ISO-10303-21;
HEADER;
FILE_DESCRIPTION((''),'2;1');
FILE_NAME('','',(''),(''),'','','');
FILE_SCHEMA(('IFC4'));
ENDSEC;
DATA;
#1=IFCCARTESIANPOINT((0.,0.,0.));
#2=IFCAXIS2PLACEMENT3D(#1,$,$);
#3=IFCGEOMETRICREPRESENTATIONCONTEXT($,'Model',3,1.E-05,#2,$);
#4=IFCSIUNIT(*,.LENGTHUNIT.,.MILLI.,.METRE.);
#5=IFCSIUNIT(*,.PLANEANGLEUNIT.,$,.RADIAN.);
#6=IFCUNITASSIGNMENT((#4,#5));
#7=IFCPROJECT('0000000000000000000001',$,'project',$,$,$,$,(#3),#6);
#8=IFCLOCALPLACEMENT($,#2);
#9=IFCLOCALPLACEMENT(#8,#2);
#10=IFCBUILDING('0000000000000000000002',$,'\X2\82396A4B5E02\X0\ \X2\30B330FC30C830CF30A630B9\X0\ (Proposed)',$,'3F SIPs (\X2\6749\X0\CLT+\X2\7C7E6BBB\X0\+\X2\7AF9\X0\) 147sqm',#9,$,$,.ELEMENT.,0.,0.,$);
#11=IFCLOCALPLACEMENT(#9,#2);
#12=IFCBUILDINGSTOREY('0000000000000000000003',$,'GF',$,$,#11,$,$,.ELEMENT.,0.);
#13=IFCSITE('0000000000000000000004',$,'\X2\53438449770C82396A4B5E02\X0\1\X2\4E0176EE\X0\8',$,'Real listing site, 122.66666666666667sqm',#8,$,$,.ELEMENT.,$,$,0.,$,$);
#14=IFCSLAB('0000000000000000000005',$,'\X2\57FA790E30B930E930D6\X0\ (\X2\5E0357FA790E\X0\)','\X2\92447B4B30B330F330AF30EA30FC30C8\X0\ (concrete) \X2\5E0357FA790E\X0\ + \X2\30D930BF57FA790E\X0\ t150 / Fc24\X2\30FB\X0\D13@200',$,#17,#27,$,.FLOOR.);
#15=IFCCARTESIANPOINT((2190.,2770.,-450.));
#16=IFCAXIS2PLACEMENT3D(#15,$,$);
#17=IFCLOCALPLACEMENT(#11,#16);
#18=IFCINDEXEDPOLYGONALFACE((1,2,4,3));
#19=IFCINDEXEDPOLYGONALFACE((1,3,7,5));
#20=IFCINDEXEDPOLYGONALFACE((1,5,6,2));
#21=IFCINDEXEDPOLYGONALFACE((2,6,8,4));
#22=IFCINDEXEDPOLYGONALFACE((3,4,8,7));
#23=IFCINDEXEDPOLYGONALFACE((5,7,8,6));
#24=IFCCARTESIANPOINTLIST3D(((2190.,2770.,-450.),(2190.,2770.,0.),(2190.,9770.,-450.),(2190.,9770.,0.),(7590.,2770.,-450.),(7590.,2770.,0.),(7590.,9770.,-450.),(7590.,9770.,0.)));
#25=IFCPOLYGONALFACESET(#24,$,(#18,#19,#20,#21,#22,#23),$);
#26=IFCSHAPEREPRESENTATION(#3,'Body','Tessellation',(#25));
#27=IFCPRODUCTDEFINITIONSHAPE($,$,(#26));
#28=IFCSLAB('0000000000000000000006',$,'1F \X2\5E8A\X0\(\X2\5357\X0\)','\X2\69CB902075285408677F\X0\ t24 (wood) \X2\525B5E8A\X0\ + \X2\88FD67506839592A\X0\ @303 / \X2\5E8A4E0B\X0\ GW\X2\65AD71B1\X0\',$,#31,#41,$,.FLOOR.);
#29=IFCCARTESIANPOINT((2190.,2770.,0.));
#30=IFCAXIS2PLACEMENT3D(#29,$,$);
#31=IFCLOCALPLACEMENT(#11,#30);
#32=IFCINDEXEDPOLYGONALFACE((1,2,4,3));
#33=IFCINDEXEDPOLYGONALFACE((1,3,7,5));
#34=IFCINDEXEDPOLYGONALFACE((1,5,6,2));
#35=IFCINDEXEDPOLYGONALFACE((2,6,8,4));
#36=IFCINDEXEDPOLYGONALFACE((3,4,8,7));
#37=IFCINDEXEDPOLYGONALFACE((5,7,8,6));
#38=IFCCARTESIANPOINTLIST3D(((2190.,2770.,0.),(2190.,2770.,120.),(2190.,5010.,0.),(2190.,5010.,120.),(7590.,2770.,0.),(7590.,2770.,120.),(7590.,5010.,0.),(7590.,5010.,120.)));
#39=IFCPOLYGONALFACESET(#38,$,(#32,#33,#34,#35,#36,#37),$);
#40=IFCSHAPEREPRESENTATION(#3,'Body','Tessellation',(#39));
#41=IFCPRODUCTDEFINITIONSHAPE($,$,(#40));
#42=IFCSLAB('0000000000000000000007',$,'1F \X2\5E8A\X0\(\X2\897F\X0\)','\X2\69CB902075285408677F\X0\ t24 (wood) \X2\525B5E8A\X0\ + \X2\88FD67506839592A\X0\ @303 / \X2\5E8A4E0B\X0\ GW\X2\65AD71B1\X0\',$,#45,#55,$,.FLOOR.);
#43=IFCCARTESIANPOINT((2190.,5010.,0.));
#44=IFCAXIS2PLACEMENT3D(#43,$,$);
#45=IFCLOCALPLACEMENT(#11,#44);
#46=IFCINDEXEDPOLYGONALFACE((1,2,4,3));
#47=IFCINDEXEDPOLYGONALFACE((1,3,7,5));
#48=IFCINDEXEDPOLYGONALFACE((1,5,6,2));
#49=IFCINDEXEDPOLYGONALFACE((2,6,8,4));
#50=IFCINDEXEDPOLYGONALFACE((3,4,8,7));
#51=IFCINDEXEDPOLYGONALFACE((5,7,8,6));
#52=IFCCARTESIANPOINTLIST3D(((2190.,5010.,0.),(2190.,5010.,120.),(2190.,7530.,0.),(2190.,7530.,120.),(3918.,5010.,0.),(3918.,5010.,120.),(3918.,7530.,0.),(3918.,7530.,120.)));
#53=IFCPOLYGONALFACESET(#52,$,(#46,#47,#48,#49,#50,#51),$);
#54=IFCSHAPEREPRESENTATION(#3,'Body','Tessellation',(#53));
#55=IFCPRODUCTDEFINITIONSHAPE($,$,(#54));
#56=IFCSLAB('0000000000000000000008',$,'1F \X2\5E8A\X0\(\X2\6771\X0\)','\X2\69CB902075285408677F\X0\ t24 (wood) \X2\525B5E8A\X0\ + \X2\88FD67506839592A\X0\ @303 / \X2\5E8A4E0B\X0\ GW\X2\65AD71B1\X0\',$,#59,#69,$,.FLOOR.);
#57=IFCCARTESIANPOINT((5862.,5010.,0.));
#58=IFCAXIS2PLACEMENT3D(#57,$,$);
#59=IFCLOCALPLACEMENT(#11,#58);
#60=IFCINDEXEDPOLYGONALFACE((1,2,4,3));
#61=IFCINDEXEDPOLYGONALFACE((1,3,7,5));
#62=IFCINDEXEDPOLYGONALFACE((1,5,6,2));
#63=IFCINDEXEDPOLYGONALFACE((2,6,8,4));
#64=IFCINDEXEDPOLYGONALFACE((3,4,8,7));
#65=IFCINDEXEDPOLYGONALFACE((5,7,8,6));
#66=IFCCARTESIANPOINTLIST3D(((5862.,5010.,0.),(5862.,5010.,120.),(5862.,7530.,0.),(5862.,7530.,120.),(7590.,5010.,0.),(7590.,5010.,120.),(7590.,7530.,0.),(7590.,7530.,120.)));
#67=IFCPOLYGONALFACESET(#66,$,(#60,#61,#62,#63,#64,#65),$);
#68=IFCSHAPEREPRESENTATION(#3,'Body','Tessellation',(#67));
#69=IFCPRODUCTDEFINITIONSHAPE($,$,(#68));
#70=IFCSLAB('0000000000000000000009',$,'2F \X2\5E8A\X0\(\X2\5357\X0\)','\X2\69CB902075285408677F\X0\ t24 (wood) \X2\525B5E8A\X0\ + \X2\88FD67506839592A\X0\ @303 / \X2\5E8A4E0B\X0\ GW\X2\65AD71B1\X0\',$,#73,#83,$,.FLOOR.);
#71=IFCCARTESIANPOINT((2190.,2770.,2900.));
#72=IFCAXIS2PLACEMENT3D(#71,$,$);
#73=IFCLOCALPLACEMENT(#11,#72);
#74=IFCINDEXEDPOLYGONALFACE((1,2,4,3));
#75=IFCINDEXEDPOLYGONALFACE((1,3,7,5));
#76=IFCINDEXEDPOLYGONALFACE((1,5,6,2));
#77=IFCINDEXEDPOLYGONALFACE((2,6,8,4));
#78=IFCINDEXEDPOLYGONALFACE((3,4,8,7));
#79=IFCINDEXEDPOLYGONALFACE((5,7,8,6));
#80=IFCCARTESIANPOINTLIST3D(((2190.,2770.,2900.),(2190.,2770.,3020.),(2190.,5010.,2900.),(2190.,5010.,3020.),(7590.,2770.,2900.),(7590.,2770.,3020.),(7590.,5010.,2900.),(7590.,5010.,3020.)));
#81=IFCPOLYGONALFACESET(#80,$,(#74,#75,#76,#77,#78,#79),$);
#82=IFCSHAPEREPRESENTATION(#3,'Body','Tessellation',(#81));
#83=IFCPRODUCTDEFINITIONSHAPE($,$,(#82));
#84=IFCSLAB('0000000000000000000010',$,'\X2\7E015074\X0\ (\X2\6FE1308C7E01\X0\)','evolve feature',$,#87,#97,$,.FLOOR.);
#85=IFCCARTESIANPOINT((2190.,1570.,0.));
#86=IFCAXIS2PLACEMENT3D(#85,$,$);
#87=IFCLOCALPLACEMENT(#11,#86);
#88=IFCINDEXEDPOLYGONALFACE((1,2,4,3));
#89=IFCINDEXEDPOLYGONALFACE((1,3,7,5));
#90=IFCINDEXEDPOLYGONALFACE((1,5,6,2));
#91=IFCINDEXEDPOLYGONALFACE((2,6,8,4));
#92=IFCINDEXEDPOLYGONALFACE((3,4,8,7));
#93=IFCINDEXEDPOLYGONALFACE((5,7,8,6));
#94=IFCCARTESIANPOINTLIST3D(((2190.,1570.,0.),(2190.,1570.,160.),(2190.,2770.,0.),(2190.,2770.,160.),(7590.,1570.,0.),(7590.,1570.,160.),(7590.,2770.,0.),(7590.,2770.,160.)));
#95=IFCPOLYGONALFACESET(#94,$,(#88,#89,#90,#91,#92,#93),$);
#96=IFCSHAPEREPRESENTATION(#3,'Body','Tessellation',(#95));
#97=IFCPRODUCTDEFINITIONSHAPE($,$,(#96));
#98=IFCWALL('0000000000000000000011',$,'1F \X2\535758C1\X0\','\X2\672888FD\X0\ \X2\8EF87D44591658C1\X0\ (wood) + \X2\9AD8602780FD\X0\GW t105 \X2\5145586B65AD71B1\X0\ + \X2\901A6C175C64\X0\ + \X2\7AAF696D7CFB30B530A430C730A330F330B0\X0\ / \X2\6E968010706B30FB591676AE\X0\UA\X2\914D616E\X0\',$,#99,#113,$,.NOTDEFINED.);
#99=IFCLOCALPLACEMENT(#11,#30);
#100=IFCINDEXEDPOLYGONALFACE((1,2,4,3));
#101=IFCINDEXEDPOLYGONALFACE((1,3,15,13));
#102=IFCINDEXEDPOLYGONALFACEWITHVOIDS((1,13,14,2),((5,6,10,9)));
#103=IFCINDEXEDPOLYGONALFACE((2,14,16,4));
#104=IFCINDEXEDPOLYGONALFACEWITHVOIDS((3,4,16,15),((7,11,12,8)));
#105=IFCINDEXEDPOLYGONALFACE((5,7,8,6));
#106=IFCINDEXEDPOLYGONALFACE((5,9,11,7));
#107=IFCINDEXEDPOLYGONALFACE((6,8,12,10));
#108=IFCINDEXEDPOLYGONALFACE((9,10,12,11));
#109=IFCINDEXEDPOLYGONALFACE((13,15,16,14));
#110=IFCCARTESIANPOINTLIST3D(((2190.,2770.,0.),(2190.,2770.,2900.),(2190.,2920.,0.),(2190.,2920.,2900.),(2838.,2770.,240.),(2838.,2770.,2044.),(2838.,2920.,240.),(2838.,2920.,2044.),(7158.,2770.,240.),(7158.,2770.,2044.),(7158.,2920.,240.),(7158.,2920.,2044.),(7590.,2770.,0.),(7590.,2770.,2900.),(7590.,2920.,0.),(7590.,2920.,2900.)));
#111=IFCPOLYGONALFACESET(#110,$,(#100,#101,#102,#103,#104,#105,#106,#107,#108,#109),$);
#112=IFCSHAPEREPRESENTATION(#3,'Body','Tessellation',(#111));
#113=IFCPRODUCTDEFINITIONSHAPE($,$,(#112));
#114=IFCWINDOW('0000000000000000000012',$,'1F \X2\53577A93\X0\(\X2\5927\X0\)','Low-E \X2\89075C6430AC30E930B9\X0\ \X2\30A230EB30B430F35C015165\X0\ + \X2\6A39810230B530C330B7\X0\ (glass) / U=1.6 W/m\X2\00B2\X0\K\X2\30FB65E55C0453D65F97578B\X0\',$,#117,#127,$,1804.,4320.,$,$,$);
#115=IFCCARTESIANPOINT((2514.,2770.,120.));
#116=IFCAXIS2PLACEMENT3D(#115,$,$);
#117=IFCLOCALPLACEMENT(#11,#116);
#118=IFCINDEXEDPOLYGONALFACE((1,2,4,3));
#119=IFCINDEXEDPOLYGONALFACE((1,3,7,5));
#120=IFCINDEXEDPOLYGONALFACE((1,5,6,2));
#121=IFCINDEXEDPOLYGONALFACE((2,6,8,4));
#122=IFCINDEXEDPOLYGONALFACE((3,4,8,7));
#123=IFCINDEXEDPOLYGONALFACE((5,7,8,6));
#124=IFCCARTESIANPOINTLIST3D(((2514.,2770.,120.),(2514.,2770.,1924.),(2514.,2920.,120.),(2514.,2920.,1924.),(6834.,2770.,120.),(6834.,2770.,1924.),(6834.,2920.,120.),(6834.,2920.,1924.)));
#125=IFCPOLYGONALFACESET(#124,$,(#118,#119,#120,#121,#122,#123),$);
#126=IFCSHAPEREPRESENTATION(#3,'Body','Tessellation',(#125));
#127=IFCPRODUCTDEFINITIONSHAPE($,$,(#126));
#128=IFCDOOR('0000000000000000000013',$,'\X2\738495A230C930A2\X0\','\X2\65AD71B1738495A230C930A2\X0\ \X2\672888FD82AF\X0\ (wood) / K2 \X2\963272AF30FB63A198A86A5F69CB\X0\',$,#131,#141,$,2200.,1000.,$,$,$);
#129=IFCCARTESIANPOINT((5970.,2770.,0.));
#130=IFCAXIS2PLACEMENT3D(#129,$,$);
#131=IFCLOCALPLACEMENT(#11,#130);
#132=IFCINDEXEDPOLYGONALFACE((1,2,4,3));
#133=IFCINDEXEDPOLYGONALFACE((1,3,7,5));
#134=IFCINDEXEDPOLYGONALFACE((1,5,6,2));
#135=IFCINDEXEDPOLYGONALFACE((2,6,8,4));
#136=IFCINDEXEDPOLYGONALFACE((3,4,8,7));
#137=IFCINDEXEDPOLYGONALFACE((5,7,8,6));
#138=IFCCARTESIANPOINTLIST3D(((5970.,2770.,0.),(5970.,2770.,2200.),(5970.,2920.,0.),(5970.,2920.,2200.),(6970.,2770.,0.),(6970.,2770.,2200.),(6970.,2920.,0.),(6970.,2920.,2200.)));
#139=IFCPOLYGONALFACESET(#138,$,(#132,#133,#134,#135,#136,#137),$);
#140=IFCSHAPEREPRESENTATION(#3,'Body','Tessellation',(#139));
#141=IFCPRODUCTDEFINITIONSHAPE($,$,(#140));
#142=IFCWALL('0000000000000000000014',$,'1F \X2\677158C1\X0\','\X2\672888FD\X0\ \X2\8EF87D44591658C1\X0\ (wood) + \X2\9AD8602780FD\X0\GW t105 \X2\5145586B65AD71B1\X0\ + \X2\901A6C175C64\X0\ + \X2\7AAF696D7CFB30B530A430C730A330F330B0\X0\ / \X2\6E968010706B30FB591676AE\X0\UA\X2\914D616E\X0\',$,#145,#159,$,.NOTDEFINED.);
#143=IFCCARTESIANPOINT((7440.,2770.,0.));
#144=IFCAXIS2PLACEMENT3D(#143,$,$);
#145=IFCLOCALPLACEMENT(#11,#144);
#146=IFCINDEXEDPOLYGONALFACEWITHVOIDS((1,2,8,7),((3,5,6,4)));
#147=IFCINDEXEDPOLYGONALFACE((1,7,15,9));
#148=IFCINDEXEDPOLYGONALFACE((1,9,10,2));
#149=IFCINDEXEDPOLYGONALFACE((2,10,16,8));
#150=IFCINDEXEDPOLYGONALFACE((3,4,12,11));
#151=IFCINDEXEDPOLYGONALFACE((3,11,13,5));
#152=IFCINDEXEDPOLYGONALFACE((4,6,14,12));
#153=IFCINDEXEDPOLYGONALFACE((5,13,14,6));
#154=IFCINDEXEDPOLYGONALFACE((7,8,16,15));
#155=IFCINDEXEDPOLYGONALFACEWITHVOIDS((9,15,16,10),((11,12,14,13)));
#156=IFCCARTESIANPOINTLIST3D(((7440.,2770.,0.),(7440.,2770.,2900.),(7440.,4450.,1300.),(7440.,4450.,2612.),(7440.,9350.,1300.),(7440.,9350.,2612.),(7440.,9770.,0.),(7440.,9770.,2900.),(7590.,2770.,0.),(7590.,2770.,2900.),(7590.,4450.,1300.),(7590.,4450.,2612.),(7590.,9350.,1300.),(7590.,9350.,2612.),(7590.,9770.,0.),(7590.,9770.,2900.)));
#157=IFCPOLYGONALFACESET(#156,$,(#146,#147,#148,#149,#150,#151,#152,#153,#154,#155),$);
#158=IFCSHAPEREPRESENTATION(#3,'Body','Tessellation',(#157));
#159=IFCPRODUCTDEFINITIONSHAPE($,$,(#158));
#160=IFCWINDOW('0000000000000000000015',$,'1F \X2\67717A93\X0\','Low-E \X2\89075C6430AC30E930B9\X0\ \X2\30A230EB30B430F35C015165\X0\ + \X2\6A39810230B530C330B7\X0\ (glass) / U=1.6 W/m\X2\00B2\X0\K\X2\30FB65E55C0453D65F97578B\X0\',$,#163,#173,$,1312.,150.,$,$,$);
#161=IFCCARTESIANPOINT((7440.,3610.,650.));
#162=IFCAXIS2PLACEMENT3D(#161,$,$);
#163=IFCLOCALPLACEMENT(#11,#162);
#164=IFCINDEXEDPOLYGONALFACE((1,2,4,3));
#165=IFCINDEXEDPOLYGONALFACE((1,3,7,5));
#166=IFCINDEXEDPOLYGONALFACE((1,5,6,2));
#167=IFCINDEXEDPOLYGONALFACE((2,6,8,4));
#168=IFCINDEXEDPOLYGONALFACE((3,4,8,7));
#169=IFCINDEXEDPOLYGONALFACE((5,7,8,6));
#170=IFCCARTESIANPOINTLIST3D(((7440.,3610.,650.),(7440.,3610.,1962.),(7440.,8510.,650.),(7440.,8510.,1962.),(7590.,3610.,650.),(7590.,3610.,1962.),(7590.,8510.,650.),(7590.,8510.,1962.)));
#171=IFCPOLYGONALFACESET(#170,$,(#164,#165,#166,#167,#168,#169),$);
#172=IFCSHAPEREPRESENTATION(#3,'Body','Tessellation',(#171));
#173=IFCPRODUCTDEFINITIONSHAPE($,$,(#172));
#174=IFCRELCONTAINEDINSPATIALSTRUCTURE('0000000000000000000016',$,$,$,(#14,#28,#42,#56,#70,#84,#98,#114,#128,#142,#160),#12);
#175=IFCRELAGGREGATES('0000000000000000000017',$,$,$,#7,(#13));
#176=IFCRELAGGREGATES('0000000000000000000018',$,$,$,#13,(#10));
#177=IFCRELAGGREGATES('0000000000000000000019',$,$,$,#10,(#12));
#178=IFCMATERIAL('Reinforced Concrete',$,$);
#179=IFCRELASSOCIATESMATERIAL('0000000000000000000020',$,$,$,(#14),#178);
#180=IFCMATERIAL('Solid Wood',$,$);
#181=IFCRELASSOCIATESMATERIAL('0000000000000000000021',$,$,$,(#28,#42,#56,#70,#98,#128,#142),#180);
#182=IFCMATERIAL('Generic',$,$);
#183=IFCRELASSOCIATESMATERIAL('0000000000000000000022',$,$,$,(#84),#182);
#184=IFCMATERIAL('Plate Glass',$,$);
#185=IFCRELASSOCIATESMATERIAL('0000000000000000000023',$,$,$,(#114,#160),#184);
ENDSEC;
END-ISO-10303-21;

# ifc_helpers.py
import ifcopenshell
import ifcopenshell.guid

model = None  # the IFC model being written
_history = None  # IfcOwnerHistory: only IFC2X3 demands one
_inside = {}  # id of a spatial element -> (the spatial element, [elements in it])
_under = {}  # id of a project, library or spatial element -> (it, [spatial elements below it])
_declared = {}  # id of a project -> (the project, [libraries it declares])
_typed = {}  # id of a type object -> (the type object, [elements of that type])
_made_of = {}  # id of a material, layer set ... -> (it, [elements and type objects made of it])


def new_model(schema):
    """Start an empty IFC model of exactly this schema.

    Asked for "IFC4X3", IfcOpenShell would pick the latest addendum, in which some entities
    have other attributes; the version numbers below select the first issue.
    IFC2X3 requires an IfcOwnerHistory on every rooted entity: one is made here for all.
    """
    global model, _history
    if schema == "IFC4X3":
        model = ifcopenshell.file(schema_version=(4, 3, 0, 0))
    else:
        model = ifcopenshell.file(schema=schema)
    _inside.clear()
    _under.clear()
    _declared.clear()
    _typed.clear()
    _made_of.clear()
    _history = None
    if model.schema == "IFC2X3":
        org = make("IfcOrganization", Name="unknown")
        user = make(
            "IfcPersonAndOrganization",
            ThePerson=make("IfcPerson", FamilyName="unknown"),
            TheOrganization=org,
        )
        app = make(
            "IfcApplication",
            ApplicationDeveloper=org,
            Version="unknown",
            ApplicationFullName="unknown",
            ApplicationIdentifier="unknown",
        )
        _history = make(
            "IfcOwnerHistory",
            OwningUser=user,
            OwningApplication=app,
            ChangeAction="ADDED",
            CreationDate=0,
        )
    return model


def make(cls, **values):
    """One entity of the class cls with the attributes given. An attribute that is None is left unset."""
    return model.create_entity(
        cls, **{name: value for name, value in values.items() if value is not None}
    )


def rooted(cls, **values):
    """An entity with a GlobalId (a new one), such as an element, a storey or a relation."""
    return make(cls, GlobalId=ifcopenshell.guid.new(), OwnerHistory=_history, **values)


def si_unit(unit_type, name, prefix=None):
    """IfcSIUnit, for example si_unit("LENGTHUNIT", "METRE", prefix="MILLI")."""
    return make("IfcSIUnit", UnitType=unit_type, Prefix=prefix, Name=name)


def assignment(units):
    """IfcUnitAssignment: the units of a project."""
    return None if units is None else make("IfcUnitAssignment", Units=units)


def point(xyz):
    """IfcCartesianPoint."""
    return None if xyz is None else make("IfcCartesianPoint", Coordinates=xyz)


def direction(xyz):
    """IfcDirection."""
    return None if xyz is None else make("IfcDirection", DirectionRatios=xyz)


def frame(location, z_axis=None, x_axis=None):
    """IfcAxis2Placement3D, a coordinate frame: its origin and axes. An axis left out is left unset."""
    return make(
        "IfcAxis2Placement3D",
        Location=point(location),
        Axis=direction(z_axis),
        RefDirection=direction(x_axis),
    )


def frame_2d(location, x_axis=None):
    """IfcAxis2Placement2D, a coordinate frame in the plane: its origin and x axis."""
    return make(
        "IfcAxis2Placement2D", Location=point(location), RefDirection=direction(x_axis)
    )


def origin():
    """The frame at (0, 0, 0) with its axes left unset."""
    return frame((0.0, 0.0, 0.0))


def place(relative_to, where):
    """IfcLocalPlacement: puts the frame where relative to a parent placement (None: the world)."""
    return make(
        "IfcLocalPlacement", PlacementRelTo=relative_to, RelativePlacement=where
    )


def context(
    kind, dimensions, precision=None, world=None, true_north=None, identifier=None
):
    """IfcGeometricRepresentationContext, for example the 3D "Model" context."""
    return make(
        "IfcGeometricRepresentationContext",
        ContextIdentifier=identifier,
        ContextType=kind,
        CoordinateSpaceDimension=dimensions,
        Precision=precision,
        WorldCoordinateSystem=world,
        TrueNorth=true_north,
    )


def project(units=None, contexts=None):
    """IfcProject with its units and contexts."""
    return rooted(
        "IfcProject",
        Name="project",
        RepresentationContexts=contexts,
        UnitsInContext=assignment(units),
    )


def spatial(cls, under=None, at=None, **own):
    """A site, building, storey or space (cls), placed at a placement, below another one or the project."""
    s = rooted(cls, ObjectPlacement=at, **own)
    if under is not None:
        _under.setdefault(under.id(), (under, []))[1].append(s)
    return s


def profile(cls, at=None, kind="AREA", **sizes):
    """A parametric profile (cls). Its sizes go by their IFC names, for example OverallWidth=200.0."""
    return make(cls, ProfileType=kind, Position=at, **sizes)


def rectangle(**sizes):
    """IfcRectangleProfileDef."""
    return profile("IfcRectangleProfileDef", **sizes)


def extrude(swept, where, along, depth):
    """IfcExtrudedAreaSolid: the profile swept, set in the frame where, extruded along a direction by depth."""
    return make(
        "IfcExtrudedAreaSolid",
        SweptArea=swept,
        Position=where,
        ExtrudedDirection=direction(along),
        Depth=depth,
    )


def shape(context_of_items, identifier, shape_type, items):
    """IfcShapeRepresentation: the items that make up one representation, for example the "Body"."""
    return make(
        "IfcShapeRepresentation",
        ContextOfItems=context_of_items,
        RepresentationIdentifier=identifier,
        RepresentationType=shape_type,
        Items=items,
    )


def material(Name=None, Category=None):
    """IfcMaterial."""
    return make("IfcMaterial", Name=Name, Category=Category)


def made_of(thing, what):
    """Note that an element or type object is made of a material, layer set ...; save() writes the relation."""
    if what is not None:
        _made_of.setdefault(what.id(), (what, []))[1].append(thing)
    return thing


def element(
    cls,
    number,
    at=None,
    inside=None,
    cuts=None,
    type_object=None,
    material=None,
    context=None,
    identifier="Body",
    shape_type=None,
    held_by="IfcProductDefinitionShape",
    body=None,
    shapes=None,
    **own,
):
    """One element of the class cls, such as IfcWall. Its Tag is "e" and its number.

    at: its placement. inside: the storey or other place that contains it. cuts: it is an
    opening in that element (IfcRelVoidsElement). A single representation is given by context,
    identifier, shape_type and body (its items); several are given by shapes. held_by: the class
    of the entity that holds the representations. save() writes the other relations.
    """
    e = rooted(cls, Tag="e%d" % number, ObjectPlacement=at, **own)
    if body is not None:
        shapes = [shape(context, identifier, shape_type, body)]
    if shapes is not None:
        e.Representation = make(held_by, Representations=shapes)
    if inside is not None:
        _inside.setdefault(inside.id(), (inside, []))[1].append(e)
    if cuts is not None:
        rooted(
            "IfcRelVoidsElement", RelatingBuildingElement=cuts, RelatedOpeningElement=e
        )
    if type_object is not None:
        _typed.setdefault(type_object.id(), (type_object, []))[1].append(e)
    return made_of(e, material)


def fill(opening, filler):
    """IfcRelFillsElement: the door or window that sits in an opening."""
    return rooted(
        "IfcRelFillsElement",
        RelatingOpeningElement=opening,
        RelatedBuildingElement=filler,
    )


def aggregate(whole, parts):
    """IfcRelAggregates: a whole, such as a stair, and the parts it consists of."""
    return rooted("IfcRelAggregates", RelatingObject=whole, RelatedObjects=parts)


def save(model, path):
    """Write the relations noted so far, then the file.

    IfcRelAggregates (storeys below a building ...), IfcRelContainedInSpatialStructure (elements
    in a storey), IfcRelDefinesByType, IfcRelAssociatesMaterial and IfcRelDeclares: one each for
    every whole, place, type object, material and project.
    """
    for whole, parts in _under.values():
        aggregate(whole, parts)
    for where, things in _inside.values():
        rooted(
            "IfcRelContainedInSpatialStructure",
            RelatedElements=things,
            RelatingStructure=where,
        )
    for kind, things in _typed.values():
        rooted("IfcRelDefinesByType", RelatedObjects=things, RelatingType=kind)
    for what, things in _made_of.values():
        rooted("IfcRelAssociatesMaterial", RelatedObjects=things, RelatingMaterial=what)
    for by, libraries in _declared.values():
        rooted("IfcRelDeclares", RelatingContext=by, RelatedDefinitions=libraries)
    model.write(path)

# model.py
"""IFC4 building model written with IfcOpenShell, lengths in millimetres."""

from ifc_helpers import new_model, si_unit, frame, frame_2d, origin, place, context, project, spatial, rectangle, extrude, material, element, fill, save


model = new_model("IFC4")

# Units and contexts
model_context = context("Model", 3, precision=1e-05, world=origin())
ifc_project = project(units=[si_unit("LENGTHUNIT", "METRE", prefix="MILLI"), si_unit("PLANEANGLEUNIT", "RADIAN")], contexts=[model_context])

# Site, building, storey
site_placement = place(None, origin())
site = spatial("IfcSite", under=ifc_project, at=site_placement, Name="千葉県船橋市1丁目8", ObjectType="Real listing site, 122.66666666666667sqm", CompositionType="ELEMENT", RefElevation=0.0)
building_placement = place(site_placement, origin())
building = spatial("IfcBuilding", under=site, at=building_placement, Name="船橋市 コートハウス (Proposed)", ObjectType="3F SIPs (杉CLT+籾殻+竹) 147sqm", CompositionType="ELEMENT", ElevationOfRefHeight=0.0, ElevationOfTerrain=0.0)
storey_placement = place(building_placement, origin())
storey = spatial("IfcBuildingStorey", under=building, at=storey_placement, Name="GF", CompositionType="ELEMENT", Elevation=0.0)

# Slabs
ifc_material_1 = material(Name="Reinforced Concrete")
slab_1_placement = place(storey_placement, frame((2190.0, 2770.0, -450.0)))
element("IfcSlab", 1, at=slab_1_placement, inside=storey, material=ifc_material_1, Name="基礎スラブ (布基礎)", Description="鉄筋コンクリート (concrete) 布基礎 + ベタ基礎 t150 / Fc24・D13@200", PredefinedType="FLOOR", context=model_context, shape_type="SweptSolid", body=[
    extrude(rectangle(XDim=5400.0, YDim=7000.0, at=frame_2d((2700.0, 3500.0))), frame((2190.0, 2770.0, -450.0)), (0.0, 0.0, 1.0), 450.0),
])
ifc_material_2 = material(Name="Solid Wood")
slab_2_placement = place(storey_placement, frame((2190.0, 2770.0, 0.0)))
element("IfcSlab", 2, at=slab_2_placement, inside=storey, material=ifc_material_2, Name="1F 床(南)", Description="構造用合板 t24 (wood) 剛床 + 製材根太 @303 / 床下 GW断熱", PredefinedType="FLOOR", context=model_context, shape_type="SweptSolid", body=[
    extrude(rectangle(XDim=5400.0, YDim=2240.0, at=frame_2d((2700.0, 1120.0))), frame((2190.0, 2770.0, 0.0)), (0.0, 0.0, 1.0), 120.0),
])
slab_3_placement = place(storey_placement, frame((2190.0, 5010.0, 0.0)))
element("IfcSlab", 3, at=slab_3_placement, inside=storey, material=ifc_material_2, Name="1F 床(西)", Description="構造用合板 t24 (wood) 剛床 + 製材根太 @303 / 床下 GW断熱", PredefinedType="FLOOR", context=model_context, shape_type="SweptSolid", body=[
    extrude(rectangle(XDim=1728.0, YDim=2520.0, at=frame_2d((864.0, 1260.0))), frame((2190.0, 5010.0, 0.0)), (0.0, 0.0, 1.0), 120.0),
])
slab_4_placement = place(storey_placement, frame((5862.0, 5010.0, 0.0)))
element("IfcSlab", 4, at=slab_4_placement, inside=storey, material=ifc_material_2, Name="1F 床(東)", Description="構造用合板 t24 (wood) 剛床 + 製材根太 @303 / 床下 GW断熱", PredefinedType="FLOOR", context=model_context, shape_type="SweptSolid", body=[
    extrude(rectangle(XDim=1728.0, YDim=2520.0, at=frame_2d((864.0, 1260.0))), frame((5862.0, 5010.0, 0.0)), (0.0, 0.0, 1.0), 120.0),
])
slab_5_placement = place(storey_placement, frame((2190.0, 2770.0, 2900.0)))
element("IfcSlab", 5, at=slab_5_placement, inside=storey, material=ifc_material_2, Name="2F 床(南)", Description="構造用合板 t24 (wood) 剛床 + 製材根太 @303 / 床下 GW断熱", PredefinedType="FLOOR", context=model_context, shape_type="SweptSolid", body=[
    extrude(rectangle(XDim=5400.0, YDim=2240.0, at=frame_2d((2700.0, 1120.0))), frame((2190.0, 2770.0, 2900.0)), (0.0, 0.0, 1.0), 120.0),
])
ifc_material_3 = material(Name="Generic")
slab_6_placement = place(storey_placement, frame((2190.0, 1570.0, 0.0)))
element("IfcSlab", 6, at=slab_6_placement, inside=storey, material=ifc_material_3, Name="縁側 (濡れ縁)", Description="evolve feature", PredefinedType="FLOOR", context=model_context, shape_type="SweptSolid", body=[
    extrude(rectangle(XDim=5400.0, YDim=1200.0, at=frame_2d((2700.0, 600.0))), frame((2190.0, 1570.0, 0.0)), (0.0, 0.0, 1.0), 160.0),
])

# Wall, openings, window, door
wall_1_placement = place(storey_placement, frame((2190.0, 2770.0, 0.0)))
wall_1 = element("IfcWall", 7, at=wall_1_placement, inside=storey, material=ifc_material_2, Name="1F 南壁", Description="木製 軸組外壁 (wood) + 高性能GW t105 充填断熱 + 通気層 + 窯業系サイディング / 準耐火・外皮UA配慮", PredefinedType="NOTDEFINED", context=model_context, shape_type="SweptSolid", body=[
    extrude(rectangle(XDim=5400.0, YDim=150.0, at=frame_2d((2700.0, 75.0))), frame((2190.0, 2770.0, 0.0)), (0.0, 0.0, 1.0), 2900.0),
])
opening_1_placement = place(storey_placement, frame((2514.0, 2770.0, 120.0)))
opening_1 = element("IfcOpeningElement", 8, at=opening_1_placement, cuts=wall_1, PredefinedType="NOTDEFINED", context=model_context, shape_type="SweptSolid", body=[
    extrude(rectangle(XDim=4320.0, YDim=150.0, at=frame_2d((2160.0, 75.0))), frame((2514.0, 2770.0, 120.0)), (0.0, 0.0, 1.0), 1804.0),
])
opening_2_placement = place(storey_placement, frame((5970.0, 2770.0, 0.0)))
opening_2 = element("IfcOpeningElement", 9, at=opening_2_placement, cuts=wall_1, PredefinedType="NOTDEFINED", context=model_context, shape_type="SweptSolid", body=[
    extrude(rectangle(XDim=1000.0, YDim=150.0, at=frame_2d((500.0, 75.0))), frame((5970.0, 2770.0, 0.0)), (0.0, 0.0, 1.0), 2200.0),
])
ifc_material_4 = material(Name="Plate Glass")
window_1_placement = place(storey_placement, frame((2514.0, 2770.0, 120.0)))
window_1 = element("IfcWindow", 10, at=window_1_placement, inside=storey, material=ifc_material_4, Name="1F 南窓(大)", Description="Low-E 複層ガラス アルゴン封入 + 樹脂サッシ (glass) / U=1.6 W/m²K・日射取得型", OverallHeight=1804.0, OverallWidth=4320.0, context=model_context, shape_type="SweptSolid", body=[
    extrude(rectangle(XDim=4320.0, YDim=150.0, at=frame_2d((2160.0, 75.0))), frame((2514.0, 2770.0, 120.0)), (0.0, 0.0, 1.0), 1804.0),
])
fill(opening_1, window_1)
door_placement = place(storey_placement, frame((5970.0, 2770.0, 0.0)))
door = element("IfcDoor", 11, at=door_placement, inside=storey, material=ifc_material_2, Name="玄関ドア", Description="断熱玄関ドア 木製芯 (wood) / K2 防犯・採風機構", OverallHeight=2200.0, OverallWidth=1000.0, context=model_context, shape_type="SweptSolid", body=[
    extrude(rectangle(XDim=1000.0, YDim=150.0, at=frame_2d((500.0, 75.0))), frame((5970.0, 2770.0, 0.0)), (0.0, 0.0, 1.0), 2200.0),
])
fill(opening_2, door)

# Wall, opening, window
wall_2_placement = place(storey_placement, frame((7440.0, 2770.0, 0.0)))
wall_2 = element("IfcWall", 12, at=wall_2_placement, inside=storey, material=ifc_material_2, Name="1F 東壁", Description="木製 軸組外壁 (wood) + 高性能GW t105 充填断熱 + 通気層 + 窯業系サイディング / 準耐火・外皮UA配慮", PredefinedType="NOTDEFINED", context=model_context, shape_type="SweptSolid", body=[
    extrude(rectangle(XDim=150.0, YDim=7000.0, at=frame_2d((75.0, 3500.0))), frame((7440.0, 2770.0, 0.0)), (0.0, 0.0, 1.0), 2900.0),
])
opening_3_placement = place(storey_placement, frame((7440.0, 3610.0, 650.0)))
opening_3 = element("IfcOpeningElement", 13, at=opening_3_placement, cuts=wall_2, PredefinedType="NOTDEFINED", context=model_context, shape_type="SweptSolid", body=[
    extrude(rectangle(XDim=150.0, YDim=4900.0, at=frame_2d((75.0, 2450.0))), frame((7440.0, 3610.0, 650.0)), (0.0, 0.0, 1.0), 1312.0),
])
window_2_placement = place(storey_placement, frame((7440.0, 3610.0, 650.0)))
window_2 = element("IfcWindow", 14, at=window_2_placement, inside=storey, material=ifc_material_4, Name="1F 東窓", Description="Low-E 複層ガラス アルゴン封入 + 樹脂サッシ (glass) / U=1.6 W/m²K・日射取得型", OverallHeight=1312.0, OverallWidth=150.0, context=model_context, shape_type="SweptSolid", body=[
    extrude(rectangle(XDim=150.0, YDim=4900.0, at=frame_2d((75.0, 2450.0))), frame((7440.0, 3610.0, 650.0)), (0.0, 0.0, 1.0), 1312.0),
])
fill(opening_3, window_2)

save(model, "model.ifc")
